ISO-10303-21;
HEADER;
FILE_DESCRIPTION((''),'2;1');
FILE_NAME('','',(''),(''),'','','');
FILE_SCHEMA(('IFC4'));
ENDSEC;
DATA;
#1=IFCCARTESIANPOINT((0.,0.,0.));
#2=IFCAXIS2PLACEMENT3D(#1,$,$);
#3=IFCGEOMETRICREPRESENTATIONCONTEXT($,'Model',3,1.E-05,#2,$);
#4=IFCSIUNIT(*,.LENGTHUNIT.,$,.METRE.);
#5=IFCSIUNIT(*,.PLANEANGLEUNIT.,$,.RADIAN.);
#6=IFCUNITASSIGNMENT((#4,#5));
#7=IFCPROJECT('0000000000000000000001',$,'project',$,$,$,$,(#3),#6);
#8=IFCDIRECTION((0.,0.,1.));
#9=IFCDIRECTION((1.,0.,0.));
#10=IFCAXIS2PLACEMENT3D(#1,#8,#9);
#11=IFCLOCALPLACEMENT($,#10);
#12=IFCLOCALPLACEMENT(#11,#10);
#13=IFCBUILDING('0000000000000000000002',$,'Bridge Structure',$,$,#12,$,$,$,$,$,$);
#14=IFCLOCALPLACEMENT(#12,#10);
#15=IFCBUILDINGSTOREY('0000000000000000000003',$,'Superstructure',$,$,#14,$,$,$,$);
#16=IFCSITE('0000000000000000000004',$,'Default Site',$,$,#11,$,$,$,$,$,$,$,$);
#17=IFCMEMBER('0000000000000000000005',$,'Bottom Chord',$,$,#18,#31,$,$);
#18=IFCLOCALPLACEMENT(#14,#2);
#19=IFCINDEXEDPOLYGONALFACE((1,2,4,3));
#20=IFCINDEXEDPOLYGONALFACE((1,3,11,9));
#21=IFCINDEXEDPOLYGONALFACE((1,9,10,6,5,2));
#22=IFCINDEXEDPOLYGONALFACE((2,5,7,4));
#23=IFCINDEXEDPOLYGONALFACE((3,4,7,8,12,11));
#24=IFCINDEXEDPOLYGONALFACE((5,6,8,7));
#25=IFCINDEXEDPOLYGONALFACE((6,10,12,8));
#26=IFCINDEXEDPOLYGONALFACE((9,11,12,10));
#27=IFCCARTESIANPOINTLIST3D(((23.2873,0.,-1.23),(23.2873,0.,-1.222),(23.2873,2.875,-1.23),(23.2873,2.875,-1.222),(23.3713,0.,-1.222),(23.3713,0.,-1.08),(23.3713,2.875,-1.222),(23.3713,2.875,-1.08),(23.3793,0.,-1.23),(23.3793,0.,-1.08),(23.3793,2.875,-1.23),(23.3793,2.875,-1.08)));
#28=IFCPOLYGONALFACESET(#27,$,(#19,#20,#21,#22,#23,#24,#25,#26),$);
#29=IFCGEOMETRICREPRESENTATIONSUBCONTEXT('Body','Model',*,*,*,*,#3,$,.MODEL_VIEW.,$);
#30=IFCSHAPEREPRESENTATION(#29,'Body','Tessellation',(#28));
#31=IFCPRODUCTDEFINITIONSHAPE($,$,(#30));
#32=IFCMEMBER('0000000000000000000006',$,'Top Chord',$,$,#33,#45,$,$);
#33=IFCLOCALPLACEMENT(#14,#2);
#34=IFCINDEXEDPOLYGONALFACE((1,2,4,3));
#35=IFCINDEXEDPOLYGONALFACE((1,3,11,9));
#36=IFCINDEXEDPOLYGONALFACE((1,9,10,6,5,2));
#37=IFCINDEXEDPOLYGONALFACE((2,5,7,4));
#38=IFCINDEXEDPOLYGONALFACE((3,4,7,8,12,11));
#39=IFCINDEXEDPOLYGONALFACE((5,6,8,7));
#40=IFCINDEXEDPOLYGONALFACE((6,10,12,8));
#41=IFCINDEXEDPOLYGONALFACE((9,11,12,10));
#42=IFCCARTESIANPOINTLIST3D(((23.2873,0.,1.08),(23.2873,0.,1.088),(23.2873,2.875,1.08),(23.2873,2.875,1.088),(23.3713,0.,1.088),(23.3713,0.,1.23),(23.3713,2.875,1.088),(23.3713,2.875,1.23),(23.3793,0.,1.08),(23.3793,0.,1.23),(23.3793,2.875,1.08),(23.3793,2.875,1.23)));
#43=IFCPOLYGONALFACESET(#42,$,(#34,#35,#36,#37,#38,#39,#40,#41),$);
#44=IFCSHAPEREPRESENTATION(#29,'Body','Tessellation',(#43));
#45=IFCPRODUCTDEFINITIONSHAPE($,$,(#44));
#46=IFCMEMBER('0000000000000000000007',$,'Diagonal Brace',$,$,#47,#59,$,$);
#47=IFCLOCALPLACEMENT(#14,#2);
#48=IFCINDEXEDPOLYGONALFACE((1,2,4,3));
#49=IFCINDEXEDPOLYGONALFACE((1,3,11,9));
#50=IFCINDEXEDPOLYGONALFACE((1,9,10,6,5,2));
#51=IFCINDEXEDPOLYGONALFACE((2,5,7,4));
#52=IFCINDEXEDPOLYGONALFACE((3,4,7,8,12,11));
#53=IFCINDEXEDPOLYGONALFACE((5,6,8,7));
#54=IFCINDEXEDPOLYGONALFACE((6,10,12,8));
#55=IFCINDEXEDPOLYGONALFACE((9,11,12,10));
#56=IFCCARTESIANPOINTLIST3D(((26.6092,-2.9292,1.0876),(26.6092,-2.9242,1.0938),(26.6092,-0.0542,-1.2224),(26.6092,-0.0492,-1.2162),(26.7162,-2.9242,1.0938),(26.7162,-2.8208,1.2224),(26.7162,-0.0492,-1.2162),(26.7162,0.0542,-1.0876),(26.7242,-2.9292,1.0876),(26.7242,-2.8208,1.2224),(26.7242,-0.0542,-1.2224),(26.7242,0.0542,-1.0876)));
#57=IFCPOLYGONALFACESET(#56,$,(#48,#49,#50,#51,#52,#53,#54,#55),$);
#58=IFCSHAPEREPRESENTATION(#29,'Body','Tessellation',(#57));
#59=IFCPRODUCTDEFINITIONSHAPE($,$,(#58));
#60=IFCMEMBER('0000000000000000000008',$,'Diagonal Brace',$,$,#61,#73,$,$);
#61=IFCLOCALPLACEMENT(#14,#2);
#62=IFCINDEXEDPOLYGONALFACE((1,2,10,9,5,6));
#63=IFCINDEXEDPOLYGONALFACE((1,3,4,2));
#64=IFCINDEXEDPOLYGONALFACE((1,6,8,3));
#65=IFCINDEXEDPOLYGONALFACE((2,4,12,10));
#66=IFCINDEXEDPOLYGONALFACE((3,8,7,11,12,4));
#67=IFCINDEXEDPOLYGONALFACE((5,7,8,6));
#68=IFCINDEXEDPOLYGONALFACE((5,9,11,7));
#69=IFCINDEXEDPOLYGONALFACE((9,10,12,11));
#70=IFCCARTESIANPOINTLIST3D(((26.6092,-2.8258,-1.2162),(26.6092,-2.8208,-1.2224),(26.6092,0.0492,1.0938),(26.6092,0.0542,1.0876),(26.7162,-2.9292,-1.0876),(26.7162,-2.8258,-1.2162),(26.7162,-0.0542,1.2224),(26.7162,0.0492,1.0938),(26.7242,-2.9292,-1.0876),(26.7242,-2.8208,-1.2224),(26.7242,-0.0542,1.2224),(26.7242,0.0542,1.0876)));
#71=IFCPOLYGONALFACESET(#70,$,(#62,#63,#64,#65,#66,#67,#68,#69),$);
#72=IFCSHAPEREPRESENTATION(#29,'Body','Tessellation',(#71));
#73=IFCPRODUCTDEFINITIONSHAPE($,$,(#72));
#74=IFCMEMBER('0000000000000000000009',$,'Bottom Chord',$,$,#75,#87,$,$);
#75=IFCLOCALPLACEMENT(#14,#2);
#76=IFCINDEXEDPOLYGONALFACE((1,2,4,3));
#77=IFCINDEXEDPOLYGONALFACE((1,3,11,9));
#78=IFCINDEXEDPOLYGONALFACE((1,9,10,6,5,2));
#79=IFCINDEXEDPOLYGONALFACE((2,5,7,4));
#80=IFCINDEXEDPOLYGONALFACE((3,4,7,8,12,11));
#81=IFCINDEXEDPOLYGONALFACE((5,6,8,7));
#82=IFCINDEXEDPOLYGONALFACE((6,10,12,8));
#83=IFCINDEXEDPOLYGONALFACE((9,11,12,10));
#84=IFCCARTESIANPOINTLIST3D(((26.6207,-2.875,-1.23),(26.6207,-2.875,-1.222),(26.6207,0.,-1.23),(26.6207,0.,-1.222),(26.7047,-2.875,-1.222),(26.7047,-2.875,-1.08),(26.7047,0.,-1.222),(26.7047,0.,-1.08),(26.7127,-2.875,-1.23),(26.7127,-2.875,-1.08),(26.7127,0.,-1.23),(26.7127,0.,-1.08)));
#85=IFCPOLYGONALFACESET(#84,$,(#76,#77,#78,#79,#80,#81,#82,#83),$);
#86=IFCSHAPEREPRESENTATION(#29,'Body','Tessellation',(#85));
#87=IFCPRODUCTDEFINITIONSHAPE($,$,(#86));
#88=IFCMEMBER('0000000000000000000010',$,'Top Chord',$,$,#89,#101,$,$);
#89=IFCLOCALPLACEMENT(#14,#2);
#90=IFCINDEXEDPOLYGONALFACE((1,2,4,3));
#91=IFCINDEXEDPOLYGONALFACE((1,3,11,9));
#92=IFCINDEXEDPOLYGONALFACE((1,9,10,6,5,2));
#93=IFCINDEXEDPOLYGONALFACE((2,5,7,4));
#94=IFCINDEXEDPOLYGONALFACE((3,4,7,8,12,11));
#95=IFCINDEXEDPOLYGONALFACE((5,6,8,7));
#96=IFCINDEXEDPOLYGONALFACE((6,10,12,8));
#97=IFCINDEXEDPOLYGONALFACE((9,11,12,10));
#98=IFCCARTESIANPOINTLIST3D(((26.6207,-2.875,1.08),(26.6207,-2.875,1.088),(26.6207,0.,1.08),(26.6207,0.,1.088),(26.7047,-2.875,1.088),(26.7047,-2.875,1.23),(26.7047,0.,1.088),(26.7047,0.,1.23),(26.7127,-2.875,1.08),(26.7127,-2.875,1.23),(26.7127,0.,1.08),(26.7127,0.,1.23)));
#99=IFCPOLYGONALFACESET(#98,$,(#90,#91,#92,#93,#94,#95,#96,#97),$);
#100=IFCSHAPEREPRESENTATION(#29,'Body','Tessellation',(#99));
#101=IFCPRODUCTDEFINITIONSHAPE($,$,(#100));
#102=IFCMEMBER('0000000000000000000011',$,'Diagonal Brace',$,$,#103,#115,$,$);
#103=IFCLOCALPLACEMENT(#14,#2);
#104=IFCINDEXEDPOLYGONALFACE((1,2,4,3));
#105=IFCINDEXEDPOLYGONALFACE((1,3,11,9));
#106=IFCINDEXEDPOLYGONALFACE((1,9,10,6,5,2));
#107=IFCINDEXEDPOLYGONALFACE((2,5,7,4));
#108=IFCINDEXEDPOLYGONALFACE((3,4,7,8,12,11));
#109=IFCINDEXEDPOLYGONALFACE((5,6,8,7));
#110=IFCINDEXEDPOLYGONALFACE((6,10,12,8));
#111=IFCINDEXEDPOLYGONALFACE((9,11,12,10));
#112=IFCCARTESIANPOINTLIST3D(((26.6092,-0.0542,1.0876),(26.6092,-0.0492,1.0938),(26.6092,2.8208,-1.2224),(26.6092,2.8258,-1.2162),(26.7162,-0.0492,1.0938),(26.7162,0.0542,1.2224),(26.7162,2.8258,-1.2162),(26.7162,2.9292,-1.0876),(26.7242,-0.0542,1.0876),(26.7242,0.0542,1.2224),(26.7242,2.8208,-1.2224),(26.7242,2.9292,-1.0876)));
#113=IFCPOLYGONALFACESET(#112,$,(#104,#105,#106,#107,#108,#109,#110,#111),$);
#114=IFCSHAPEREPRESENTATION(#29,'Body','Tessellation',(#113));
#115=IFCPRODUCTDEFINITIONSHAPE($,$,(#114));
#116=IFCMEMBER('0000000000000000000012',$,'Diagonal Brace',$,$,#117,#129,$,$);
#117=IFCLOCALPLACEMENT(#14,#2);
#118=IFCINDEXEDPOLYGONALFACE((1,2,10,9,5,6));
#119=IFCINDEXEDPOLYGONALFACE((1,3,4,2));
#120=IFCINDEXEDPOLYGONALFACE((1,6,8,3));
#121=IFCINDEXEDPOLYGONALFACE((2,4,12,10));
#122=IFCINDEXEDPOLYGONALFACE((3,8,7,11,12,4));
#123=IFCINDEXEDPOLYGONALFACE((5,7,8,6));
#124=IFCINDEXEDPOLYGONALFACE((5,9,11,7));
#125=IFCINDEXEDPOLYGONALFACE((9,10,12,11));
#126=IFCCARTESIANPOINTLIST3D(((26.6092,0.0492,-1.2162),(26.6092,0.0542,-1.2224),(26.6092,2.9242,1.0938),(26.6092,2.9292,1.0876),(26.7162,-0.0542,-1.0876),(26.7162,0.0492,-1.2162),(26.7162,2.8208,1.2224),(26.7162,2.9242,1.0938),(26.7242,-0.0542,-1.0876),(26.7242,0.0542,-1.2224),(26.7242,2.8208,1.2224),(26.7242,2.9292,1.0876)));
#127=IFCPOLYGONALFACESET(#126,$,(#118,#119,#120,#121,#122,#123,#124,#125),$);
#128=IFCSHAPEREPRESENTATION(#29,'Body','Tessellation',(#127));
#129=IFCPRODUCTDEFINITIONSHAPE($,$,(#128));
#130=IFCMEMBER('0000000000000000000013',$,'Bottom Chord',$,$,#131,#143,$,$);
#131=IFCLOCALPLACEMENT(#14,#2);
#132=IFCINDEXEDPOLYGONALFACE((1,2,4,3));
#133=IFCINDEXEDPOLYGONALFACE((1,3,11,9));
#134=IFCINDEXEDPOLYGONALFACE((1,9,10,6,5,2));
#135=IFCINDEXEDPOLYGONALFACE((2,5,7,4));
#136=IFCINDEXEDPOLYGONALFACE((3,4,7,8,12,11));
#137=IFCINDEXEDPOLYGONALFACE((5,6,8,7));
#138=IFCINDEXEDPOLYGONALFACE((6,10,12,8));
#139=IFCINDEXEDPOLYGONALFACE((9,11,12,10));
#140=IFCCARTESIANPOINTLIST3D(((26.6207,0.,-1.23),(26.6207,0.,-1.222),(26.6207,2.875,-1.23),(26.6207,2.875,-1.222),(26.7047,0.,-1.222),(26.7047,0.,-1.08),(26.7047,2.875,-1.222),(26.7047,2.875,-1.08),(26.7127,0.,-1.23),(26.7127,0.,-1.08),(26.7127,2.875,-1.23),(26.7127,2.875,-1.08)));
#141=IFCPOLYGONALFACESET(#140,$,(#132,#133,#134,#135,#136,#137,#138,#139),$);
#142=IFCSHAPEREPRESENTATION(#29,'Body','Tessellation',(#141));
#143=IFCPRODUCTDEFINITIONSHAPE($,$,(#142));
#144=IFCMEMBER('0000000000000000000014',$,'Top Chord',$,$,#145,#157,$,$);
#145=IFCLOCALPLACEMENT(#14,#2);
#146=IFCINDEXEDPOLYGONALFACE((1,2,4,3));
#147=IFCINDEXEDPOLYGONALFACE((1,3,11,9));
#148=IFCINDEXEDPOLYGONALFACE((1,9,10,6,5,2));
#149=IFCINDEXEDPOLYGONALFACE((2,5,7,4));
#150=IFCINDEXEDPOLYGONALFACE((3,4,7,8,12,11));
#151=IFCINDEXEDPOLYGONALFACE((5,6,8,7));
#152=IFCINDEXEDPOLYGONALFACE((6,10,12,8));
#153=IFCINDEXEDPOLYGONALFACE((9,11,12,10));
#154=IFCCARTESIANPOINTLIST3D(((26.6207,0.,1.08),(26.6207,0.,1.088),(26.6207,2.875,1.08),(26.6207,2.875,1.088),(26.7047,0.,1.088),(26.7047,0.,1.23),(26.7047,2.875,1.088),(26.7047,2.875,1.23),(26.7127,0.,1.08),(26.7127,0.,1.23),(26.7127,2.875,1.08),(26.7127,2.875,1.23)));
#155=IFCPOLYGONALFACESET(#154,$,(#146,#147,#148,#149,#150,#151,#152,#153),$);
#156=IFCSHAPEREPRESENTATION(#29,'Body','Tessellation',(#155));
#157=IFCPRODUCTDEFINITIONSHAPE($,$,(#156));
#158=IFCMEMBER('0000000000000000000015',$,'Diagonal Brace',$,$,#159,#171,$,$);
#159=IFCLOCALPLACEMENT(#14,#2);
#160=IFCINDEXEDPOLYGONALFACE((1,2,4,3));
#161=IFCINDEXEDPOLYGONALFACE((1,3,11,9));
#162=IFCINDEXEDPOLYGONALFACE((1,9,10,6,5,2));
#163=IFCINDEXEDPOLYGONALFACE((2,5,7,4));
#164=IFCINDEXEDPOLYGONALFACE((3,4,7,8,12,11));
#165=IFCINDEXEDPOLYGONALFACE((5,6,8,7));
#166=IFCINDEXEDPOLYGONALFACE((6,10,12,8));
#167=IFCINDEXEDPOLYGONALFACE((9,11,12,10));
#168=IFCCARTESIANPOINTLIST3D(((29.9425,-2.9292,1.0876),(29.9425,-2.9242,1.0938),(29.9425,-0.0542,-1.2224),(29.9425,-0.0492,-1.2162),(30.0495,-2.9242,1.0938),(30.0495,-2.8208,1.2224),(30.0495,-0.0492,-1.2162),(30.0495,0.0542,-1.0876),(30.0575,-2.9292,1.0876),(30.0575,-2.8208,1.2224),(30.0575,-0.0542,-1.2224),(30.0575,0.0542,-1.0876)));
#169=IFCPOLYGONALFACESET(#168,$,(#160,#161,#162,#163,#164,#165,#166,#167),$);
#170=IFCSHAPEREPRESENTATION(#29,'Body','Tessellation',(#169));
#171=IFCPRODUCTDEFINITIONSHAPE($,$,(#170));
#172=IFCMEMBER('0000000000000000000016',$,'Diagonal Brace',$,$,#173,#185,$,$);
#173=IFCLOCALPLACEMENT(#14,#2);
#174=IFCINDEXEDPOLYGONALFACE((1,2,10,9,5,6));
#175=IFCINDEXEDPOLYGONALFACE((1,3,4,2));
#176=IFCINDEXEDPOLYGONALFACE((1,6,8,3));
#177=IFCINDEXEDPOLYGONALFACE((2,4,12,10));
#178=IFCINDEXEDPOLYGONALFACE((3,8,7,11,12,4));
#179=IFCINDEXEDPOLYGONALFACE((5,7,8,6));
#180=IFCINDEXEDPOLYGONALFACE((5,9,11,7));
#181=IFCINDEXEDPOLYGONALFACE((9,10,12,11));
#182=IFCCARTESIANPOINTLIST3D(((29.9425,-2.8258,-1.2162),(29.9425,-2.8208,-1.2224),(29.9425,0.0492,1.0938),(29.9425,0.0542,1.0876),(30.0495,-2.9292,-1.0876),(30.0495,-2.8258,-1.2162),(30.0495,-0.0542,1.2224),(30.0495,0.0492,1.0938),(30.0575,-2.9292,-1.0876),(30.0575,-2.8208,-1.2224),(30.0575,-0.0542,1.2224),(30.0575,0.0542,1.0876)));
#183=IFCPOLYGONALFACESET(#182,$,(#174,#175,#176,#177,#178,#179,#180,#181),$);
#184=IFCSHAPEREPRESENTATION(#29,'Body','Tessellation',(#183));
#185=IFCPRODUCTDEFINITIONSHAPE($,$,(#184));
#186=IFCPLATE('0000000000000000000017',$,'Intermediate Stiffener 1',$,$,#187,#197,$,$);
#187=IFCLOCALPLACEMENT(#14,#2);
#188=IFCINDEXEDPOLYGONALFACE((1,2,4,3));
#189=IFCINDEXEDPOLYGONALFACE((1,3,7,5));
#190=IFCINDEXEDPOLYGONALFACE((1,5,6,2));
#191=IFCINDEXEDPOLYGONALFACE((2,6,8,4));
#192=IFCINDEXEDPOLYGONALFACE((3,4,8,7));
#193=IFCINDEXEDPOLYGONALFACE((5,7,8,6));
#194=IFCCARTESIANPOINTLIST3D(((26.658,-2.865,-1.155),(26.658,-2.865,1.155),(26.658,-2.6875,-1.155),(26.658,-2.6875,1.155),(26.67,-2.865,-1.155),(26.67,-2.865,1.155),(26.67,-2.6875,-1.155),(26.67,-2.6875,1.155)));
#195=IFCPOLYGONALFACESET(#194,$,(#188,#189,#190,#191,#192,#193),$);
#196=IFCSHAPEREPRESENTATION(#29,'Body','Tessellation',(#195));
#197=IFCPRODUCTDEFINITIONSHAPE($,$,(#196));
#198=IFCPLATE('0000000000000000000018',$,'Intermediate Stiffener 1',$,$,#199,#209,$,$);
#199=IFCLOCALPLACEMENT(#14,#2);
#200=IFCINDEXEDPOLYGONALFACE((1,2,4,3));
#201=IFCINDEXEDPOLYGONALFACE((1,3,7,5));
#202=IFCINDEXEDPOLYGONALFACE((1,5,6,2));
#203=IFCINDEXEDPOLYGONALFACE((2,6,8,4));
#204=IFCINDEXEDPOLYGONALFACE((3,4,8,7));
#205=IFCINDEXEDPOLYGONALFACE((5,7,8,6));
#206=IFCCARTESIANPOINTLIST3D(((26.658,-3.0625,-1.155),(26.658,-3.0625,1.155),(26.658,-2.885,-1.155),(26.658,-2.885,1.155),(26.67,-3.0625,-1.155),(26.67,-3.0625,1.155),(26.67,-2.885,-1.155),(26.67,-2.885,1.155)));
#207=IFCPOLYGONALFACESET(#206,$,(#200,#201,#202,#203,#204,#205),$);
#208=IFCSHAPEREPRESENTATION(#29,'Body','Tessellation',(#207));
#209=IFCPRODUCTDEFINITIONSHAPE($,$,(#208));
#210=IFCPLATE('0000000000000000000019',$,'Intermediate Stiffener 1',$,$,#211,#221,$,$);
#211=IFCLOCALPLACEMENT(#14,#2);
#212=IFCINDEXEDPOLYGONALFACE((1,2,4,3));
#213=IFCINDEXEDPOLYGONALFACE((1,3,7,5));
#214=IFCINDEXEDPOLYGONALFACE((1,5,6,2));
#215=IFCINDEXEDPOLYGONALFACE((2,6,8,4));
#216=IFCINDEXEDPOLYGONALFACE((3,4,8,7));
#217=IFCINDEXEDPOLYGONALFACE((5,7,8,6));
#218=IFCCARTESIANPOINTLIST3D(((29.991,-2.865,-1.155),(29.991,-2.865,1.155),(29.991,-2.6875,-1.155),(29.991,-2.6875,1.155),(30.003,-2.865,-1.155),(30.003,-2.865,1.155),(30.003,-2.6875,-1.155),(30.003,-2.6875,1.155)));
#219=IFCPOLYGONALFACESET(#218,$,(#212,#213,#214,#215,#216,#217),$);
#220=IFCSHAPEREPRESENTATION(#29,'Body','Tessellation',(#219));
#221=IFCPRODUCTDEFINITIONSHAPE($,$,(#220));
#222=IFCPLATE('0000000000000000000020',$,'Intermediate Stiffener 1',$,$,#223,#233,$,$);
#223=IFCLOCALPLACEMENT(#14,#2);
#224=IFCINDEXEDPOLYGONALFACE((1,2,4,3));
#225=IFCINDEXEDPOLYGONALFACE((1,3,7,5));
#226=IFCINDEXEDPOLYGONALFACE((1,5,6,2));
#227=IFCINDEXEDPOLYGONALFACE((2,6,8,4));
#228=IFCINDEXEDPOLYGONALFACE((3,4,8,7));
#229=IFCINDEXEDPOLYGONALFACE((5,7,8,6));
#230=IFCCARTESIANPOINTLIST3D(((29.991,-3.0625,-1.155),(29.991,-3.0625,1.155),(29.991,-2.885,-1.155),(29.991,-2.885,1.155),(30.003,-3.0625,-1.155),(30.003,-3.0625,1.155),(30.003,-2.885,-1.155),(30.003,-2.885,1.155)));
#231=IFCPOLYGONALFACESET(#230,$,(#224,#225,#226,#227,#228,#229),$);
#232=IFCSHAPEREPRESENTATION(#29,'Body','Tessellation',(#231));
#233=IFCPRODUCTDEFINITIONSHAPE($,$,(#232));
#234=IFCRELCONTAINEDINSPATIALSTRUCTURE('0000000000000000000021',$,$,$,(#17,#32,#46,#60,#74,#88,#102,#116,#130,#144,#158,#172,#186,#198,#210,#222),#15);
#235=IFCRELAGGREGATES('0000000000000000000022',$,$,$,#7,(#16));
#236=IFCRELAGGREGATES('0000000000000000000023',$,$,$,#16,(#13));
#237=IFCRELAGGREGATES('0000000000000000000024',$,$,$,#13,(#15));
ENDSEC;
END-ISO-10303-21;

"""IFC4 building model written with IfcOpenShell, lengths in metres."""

from ifc_helpers import new_model, si_unit, frame, origin, origin_with_axes, origin_2d_with_axis, place, context, subcontext, project, spatial, rectangle, l_section, extrude, element, save


model = new_model("IFC4")

# Units and contexts
model_context = context("Model", 3, precision=1e-05, world=origin())
body_context = subcontext(model_context, "Body", "Model", "MODEL_VIEW")
ifc_project = project(units=[si_unit("LENGTHUNIT", "METRE"), si_unit("PLANEANGLEUNIT", "RADIAN")], contexts=[model_context])

# Site, building, storey
site_placement = place(None, origin_with_axes())
site = spatial("IfcSite", under=ifc_project, at=site_placement, Name="Default Site")
building_placement = place(site_placement, origin_with_axes())
building = spatial("IfcBuilding", under=site, at=building_placement, Name="Bridge Structure")
storey_placement = place(building_placement, origin_with_axes())
storey = spatial("IfcBuildingStorey", under=building, at=storey_placement, Name="Superstructure")

# Members
for number, where, z_axis, x_axis, name in (
    (1, (23.3333, 0.0, -1.155), (0.0, 1.0, 0.0), (-1.0, 0.0, 0.0), "Bottom Chord"),
    (2, (23.3333, 0.0, 1.155), (0.0, 1.0, 0.0), (-1.0, 0.0, 0.0), "Top Chord"),
):
    element("IfcMember", number, at=place(storey_placement, frame(where, z_axis=z_axis, x_axis=x_axis)), inside=storey, Name=name, context=body_context, shape_type="SweptSolid", body=[
        extrude(l_section(Depth=0.15, Width=0.092, Thickness=0.008, at=origin_2d_with_axis()), origin_with_axes(), (0.0, 0.0, 1.0), 2.875),
    ])
for number, where, z_axis, x_axis, name in (
    (3, (26.6667, -2.875, 1.155), (0.0, 0.779544, -0.626347), (-1.0, 0.0, 0.0), "Diagonal Brace"),
    (4, (26.6667, -2.875, -1.155), (0.0, 0.779544, 0.626347), (-1.0, 0.0, 0.0), "Diagonal Brace"),
):
    element("IfcMember", number, at=place(storey_placement, frame(where, z_axis=z_axis, x_axis=x_axis)), inside=storey, Name=name, context=body_context, shape_type="SweptSolid", body=[
        extrude(l_section(Depth=0.173, Width=0.115, Thickness=0.008, at=origin_2d_with_axis()), origin_with_axes(), (0.0, 0.0, 1.0), 3.6881),
    ])
for number, where, z_axis, x_axis, name in (
    (5, (26.6667, -2.875, -1.155), (0.0, 1.0, 0.0), (-1.0, 0.0, 0.0), "Bottom Chord"),
    (6, (26.6667, -2.875, 1.155), (0.0, 1.0, 0.0), (-1.0, 0.0, 0.0), "Top Chord"),
):
    element("IfcMember", number, at=place(storey_placement, frame(where, z_axis=z_axis, x_axis=x_axis)), inside=storey, Name=name, context=body_context, shape_type="SweptSolid", body=[
        extrude(l_section(Depth=0.15, Width=0.092, Thickness=0.008, at=origin_2d_with_axis()), origin_with_axes(), (0.0, 0.0, 1.0), 2.875),
    ])
for number, where, z_axis, x_axis, name in (
    (7, (26.6667, 0.0, 1.155), (0.0, 0.779544, -0.626347), (-1.0, 0.0, 0.0), "Diagonal Brace"),
    (8, (26.6667, 0.0, -1.155), (0.0, 0.779544, 0.626347), (-1.0, 0.0, 0.0), "Diagonal Brace"),
):
    element("IfcMember", number, at=place(storey_placement, frame(where, z_axis=z_axis, x_axis=x_axis)), inside=storey, Name=name, context=body_context, shape_type="SweptSolid", body=[
        extrude(l_section(Depth=0.173, Width=0.115, Thickness=0.008, at=origin_2d_with_axis()), origin_with_axes(), (0.0, 0.0, 1.0), 3.6881),
    ])
for number, where, z_axis, x_axis, name in (
    (9, (26.6667, 0.0, -1.155), (0.0, 1.0, 0.0), (-1.0, 0.0, 0.0), "Bottom Chord"),
    (10, (26.6667, 0.0, 1.155), (0.0, 1.0, 0.0), (-1.0, 0.0, 0.0), "Top Chord"),
):
    element("IfcMember", number, at=place(storey_placement, frame(where, z_axis=z_axis, x_axis=x_axis)), inside=storey, Name=name, context=body_context, shape_type="SweptSolid", body=[
        extrude(l_section(Depth=0.15, Width=0.092, Thickness=0.008, at=origin_2d_with_axis()), origin_with_axes(), (0.0, 0.0, 1.0), 2.875),
    ])
for number, where, z_axis, x_axis, name in (
    (11, (30.0, -2.875, 1.155), (0.0, 0.779544, -0.626347), (-1.0, 0.0, 0.0), "Diagonal Brace"),
    (12, (30.0, -2.875, -1.155), (0.0, 0.779544, 0.626347), (-1.0, 0.0, 0.0), "Diagonal Brace"),
):
    element("IfcMember", number, at=place(storey_placement, frame(where, z_axis=z_axis, x_axis=x_axis)), inside=storey, Name=name, context=body_context, shape_type="SweptSolid", body=[
        extrude(l_section(Depth=0.173, Width=0.115, Thickness=0.008, at=origin_2d_with_axis()), origin_with_axes(), (0.0, 0.0, 1.0), 3.6881),
    ])

# Plates
for number, where, z_axis, x_axis, name in (
    (13, (26.664, -2.7763, -1.155), (0.0, 0.0, 1.0), (1.0, 0.0, 0.0), "Intermediate Stiffener 1"),
    (14, (26.664, -2.9737, -1.155), (0.0, 0.0, 1.0), (1.0, 0.0, 0.0), "Intermediate Stiffener 1"),
    (15, (29.997, -2.7763, -1.155), (0.0, 0.0, 1.0), (1.0, 0.0, 0.0), "Intermediate Stiffener 1"),
    (16, (29.997, -2.9737, -1.155), (0.0, 0.0, 1.0), (1.0, 0.0, 0.0), "Intermediate Stiffener 1"),
):
    element("IfcPlate", number, at=place(storey_placement, frame(where, z_axis=z_axis, x_axis=x_axis)), inside=storey, Name=name, context=body_context, shape_type="SweptSolid", body=[
        extrude(rectangle(XDim=0.012, YDim=0.1775, at=origin_2d_with_axis()), origin_with_axes(), (0.0, 0.0, 1.0), 2.31),
    ])

save(model, "model.ifc")
